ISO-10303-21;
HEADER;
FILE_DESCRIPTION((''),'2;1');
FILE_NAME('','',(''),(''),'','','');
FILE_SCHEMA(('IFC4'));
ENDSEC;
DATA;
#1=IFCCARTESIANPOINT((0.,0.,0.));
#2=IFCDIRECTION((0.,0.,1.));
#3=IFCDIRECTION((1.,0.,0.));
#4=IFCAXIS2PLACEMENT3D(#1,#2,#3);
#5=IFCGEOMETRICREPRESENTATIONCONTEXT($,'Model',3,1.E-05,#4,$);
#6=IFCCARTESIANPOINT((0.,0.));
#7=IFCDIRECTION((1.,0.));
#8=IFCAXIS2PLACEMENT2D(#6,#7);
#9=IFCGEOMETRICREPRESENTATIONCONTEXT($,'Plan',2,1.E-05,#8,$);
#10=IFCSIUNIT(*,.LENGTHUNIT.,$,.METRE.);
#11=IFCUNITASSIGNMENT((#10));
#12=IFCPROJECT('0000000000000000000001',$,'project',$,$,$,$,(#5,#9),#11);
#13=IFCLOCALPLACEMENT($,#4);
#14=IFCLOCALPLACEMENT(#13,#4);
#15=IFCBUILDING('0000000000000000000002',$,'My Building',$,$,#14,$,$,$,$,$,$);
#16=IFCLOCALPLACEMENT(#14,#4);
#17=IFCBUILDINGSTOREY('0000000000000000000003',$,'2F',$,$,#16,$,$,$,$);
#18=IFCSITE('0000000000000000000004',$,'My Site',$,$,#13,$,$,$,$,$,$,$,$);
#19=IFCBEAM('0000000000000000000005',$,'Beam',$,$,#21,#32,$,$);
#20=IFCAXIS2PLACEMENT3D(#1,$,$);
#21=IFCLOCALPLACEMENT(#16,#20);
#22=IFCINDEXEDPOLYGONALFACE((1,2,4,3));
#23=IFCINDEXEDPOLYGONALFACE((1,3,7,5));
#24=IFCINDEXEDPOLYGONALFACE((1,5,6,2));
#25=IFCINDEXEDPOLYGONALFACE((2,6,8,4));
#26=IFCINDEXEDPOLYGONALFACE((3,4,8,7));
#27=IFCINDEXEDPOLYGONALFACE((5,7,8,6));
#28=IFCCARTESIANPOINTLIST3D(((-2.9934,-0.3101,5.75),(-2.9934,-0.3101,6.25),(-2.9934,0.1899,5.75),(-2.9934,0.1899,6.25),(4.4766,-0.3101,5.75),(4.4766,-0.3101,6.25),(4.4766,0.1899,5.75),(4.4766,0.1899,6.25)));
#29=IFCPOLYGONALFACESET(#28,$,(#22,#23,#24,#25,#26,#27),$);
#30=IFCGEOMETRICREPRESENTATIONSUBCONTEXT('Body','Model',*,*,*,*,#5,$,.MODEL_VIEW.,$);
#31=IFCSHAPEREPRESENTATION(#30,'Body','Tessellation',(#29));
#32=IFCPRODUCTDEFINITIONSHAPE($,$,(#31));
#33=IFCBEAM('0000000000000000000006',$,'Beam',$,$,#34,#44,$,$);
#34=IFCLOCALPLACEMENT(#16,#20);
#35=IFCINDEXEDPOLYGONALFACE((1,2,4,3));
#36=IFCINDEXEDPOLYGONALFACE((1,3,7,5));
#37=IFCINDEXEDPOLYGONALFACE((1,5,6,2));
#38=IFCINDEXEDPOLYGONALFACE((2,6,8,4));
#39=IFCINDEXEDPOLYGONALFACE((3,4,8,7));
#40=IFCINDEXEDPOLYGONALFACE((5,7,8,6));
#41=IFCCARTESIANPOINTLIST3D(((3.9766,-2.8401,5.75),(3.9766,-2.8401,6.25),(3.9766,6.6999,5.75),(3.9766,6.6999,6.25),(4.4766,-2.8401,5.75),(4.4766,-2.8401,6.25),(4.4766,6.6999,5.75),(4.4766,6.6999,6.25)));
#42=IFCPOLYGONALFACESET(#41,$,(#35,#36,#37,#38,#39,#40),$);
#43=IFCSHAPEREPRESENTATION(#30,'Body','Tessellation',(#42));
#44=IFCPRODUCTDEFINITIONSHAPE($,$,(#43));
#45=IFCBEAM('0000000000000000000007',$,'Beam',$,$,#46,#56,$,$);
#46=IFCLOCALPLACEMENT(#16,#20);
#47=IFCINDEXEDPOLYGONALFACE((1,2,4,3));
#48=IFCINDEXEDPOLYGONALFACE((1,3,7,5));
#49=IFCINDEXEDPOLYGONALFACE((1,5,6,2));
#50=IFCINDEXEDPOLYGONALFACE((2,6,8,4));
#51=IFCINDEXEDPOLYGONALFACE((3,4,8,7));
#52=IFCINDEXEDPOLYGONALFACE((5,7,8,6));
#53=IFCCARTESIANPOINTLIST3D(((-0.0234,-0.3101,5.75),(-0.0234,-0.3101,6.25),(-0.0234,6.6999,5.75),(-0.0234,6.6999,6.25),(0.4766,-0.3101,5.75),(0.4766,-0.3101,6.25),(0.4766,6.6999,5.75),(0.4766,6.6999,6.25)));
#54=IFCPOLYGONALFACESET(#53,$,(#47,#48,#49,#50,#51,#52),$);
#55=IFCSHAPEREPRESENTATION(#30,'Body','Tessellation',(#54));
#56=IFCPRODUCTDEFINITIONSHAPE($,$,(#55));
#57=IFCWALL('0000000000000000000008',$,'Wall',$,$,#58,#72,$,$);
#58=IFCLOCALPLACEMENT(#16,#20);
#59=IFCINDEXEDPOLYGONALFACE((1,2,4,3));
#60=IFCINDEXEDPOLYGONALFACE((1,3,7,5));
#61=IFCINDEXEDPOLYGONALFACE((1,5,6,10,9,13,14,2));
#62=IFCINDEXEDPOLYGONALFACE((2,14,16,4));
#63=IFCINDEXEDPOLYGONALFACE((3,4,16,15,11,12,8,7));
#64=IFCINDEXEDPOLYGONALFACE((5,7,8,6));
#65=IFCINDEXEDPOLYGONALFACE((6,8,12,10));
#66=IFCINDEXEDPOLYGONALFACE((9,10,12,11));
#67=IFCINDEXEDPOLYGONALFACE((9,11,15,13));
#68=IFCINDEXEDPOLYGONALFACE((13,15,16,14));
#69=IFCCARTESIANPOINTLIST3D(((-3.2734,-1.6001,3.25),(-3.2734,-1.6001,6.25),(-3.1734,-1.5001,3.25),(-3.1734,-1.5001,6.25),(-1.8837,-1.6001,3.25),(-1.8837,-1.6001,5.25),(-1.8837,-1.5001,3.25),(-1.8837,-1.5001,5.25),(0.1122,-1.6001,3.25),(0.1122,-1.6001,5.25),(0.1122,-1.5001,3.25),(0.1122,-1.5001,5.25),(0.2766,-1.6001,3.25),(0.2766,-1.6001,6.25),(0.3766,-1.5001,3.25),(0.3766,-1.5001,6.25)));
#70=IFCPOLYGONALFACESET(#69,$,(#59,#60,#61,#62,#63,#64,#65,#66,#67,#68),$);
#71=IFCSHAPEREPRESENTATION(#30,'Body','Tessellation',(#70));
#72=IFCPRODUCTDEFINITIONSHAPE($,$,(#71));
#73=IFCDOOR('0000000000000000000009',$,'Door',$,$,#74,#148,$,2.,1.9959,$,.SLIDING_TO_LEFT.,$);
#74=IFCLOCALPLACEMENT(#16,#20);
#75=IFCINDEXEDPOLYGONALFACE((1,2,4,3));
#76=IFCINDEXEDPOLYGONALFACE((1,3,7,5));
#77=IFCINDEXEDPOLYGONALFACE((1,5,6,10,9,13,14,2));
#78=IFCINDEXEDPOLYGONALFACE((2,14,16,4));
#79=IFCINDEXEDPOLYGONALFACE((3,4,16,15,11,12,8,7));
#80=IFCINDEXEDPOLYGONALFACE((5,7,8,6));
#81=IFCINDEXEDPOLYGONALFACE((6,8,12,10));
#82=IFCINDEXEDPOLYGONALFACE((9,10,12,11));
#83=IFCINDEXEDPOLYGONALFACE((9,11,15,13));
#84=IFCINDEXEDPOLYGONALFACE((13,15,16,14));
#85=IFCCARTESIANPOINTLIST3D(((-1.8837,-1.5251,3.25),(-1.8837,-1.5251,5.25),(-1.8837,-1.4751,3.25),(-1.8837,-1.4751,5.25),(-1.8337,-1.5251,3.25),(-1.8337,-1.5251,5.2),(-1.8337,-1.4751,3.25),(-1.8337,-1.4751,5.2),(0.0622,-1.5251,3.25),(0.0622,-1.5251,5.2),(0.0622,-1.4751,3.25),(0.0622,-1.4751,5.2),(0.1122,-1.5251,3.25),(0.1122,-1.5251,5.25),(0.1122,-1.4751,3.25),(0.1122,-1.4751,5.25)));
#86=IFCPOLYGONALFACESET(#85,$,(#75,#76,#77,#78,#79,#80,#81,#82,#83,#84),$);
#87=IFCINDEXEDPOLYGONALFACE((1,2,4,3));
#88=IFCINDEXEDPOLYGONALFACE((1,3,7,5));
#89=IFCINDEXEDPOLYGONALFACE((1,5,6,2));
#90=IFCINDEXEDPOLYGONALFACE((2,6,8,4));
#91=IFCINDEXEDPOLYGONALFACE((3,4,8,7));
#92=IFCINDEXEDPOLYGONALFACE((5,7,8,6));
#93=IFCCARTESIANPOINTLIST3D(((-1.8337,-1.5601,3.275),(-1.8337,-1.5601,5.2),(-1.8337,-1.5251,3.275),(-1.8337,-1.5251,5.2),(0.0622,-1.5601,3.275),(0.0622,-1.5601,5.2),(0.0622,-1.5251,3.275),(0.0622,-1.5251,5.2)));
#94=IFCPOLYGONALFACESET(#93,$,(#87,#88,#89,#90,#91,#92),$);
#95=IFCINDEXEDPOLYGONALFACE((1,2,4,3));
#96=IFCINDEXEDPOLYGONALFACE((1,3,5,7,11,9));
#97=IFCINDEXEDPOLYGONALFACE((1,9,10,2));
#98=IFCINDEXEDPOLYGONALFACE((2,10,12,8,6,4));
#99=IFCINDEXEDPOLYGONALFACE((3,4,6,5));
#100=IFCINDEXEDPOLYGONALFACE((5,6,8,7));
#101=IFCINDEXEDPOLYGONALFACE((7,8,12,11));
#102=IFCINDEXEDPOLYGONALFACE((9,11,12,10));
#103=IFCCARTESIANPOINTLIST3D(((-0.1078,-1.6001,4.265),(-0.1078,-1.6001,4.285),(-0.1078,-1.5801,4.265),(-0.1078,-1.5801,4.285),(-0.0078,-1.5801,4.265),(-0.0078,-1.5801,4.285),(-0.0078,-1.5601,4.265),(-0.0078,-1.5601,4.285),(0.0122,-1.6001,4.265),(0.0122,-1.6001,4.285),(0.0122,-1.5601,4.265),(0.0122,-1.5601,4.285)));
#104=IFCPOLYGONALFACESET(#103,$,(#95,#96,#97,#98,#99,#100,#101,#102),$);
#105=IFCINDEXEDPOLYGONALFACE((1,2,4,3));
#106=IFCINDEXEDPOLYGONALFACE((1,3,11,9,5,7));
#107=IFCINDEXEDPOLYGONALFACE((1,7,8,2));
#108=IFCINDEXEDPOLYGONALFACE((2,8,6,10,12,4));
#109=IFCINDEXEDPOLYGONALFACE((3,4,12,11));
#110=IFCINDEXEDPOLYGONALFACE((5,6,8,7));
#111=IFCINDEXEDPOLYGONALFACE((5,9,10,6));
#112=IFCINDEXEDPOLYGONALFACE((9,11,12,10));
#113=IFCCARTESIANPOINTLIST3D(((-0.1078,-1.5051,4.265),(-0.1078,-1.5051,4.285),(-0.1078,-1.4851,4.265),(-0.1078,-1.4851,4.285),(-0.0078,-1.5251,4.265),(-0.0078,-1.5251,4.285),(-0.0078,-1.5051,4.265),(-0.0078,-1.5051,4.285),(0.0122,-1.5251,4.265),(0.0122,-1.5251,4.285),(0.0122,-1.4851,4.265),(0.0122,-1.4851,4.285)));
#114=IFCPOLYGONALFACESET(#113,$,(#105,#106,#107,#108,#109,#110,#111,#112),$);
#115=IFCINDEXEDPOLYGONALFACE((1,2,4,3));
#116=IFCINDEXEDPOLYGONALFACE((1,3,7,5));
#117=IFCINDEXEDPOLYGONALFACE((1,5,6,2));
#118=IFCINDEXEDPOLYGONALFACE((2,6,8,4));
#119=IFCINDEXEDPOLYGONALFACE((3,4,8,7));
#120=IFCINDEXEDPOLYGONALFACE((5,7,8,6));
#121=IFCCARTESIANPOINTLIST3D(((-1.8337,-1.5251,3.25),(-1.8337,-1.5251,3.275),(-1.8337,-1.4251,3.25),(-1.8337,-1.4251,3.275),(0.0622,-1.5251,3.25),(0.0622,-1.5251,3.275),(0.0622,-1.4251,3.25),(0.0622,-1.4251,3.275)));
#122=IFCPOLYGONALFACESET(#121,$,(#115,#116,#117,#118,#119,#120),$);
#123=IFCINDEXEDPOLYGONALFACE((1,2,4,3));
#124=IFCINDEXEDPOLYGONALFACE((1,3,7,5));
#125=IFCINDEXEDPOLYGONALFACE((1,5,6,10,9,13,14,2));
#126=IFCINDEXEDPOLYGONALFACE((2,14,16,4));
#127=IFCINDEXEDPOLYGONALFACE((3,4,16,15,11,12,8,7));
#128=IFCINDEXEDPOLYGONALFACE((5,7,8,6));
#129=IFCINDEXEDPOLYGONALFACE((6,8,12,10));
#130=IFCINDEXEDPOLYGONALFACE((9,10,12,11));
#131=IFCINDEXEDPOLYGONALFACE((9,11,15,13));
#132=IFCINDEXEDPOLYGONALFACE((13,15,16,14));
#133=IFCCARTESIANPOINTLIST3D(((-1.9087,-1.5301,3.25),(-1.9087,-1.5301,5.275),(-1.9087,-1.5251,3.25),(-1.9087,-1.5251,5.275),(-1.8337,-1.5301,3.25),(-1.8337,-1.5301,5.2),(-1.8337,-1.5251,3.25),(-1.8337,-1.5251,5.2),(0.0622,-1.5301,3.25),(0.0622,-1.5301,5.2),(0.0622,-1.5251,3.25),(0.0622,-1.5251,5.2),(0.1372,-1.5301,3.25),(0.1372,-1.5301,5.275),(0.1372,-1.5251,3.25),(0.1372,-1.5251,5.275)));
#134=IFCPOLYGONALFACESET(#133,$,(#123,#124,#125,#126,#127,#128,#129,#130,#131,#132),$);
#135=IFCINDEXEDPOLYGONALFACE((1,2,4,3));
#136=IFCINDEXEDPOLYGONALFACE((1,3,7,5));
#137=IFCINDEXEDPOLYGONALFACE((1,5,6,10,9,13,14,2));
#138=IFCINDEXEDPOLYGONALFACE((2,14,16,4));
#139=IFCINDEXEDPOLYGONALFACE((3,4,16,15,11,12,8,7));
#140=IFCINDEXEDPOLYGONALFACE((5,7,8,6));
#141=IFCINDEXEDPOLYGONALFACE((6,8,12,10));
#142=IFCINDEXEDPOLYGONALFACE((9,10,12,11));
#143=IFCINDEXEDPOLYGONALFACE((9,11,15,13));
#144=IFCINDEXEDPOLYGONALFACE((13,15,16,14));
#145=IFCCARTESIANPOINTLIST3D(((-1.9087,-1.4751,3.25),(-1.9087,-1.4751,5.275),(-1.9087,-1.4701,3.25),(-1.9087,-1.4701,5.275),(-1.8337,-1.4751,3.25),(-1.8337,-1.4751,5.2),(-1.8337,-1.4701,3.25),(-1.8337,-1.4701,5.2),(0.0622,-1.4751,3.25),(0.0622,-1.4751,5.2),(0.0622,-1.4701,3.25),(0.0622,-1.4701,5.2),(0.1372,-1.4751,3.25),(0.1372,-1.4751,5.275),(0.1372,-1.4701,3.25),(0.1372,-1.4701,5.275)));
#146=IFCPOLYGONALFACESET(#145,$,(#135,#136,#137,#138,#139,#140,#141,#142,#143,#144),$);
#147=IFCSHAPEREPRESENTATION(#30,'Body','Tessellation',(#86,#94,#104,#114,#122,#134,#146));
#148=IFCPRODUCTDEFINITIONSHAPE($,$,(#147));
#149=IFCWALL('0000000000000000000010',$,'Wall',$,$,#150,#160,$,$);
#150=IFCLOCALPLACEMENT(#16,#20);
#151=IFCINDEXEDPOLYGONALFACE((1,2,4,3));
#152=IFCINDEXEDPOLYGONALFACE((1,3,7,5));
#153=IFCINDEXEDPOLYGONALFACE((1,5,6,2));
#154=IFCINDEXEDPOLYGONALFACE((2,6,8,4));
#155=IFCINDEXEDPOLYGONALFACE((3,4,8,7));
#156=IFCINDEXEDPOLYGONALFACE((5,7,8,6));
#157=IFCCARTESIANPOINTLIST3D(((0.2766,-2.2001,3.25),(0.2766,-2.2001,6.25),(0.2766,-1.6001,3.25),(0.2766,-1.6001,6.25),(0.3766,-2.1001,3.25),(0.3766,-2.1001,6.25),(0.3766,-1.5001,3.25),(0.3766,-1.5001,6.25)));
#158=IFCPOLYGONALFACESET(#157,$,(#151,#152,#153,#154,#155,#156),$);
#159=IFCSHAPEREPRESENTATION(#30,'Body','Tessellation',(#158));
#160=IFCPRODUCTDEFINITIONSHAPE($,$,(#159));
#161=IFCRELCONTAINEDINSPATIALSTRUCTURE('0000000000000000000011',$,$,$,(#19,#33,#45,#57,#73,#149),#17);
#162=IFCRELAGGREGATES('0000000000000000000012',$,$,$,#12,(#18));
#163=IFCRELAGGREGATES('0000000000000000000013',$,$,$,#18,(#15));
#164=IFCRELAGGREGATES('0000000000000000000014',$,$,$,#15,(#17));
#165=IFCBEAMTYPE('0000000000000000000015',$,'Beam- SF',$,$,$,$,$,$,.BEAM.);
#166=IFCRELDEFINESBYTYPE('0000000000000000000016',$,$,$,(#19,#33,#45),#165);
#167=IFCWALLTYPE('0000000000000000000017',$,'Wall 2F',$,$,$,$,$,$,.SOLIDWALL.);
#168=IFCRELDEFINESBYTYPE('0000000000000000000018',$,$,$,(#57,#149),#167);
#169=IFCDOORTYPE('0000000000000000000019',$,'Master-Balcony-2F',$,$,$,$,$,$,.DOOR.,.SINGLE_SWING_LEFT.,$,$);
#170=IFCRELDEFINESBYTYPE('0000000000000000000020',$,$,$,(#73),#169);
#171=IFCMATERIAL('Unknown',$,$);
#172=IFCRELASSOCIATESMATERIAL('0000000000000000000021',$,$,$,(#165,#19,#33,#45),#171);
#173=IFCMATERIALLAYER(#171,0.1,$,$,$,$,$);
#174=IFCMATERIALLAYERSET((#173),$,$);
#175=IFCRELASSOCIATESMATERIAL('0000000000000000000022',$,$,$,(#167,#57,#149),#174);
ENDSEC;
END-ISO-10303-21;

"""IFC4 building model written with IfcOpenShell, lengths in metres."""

from ifc_helpers import new_model, entity, si_unit, frame, origin_with_axes, origin_2d_with_axis, place, context, subcontext, project, spatial, line, indexed_curve, rectangle, outline, extrude, shape, source, transform, mapped, material, layer, layer_set, layer_usage, material_profile, profile_set, profile_usage, type_object, type_shapes, element, fill, save


model = new_model("IFC4")

# Units and contexts
model_context = context("Model", 3, precision=1e-05, world=origin_with_axes())
plan_context = context("Plan", 2, precision=1e-05, world=origin_2d_with_axis())
body_context_1 = subcontext(model_context, "Body", "Model", "MODEL_VIEW")
body_context_2 = subcontext(plan_context, "Body", "Plan", "PLAN_VIEW")
ifc_project = project(units=[si_unit("LENGTHUNIT", "METRE")], contexts=[model_context, plan_context])

# Site, building, storey
site_placement = place(None, origin_with_axes())
site = spatial("IfcSite", under=ifc_project, at=site_placement, Name="My Site")
building_placement = place(site_placement, origin_with_axes())
building = spatial("IfcBuilding", under=site, at=building_placement, Name="My Building")
storey_placement = place(building_placement, origin_with_axes())
storey = spatial("IfcBuildingStorey", under=building, at=storey_placement, Name="2F")

# Beams
ifc_material = material(Name="Unknown")
ifc_material_profile = material_profile(ifc_material, rectangle(XDim=0.5, YDim=0.5))
ifc_profile_set = profile_set([ifc_material_profile])
ifc_profile_usage_1 = profile_usage(ifc_profile_set, cardinal=5)
beam_type = type_object("IfcBeamType", Name="Beam- SF", PredefinedType="BEAM", material=ifc_profile_set)
beam_1_placement = place(storey_placement, frame((4.4766, -0.0601, 6.0), z_axis=(-1.0, -0.000001, 0.000001), x_axis=(0.000001, -1.0, 0.0)))
element("IfcBeam", 1, at=beam_1_placement, inside=storey, type_object=beam_type, material=ifc_profile_usage_1, Name="Beam", context=body_context_1, shape_type="SweptSolid", body=[
    extrude(rectangle(XDim=0.5, YDim=0.5), origin_with_axes(), (0.0, 0.0, 1.0), 7.47),
])
ifc_profile_usage_2 = profile_usage(ifc_profile_set, cardinal=5)
beam_2_placement = place(storey_placement, frame((4.2266, -2.8401, 6.0), z_axis=(0.0, 1.0, 0.0), x_axis=(-1.0, 0.0, 0.0)))
element("IfcBeam", 2, at=beam_2_placement, inside=storey, type_object=beam_type, material=ifc_profile_usage_2, Name="Beam", context=body_context_1, shape_type="SweptSolid", body=[
    extrude(rectangle(XDim=0.5, YDim=0.5), origin_with_axes(), (0.0, 0.0, 1.0), 9.54),
])
ifc_profile_usage_3 = profile_usage(ifc_profile_set, cardinal=5)
beam_3_placement = place(storey_placement, frame((0.2266, -0.3101, 6.0), z_axis=(0.0, 1.0, 0.0), x_axis=(-1.0, 0.0, 0.0)))
element("IfcBeam", 3, at=beam_3_placement, inside=storey, type_object=beam_type, material=ifc_profile_usage_3, Name="Beam", context=body_context_1, shape_type="SweptSolid", body=[
    extrude(rectangle(XDim=0.5, YDim=0.5), origin_with_axes(), (0.0, 0.0, 1.0), 7.01),
])

# Wall, opening, door
ifc_layer = layer(ifc_material, 0.1)
ifc_layer_set = layer_set([ifc_layer])
ifc_layer_usage_1 = layer_usage(ifc_layer_set, "AXIS2", "POSITIVE", 0.0)
wall_type = type_object("IfcWallType", Name="Wall 2F", PredefinedType="SOLIDWALL", material=ifc_layer_set)
wall_1_placement = place(storey_placement, frame((-3.2734, -1.6001, 3.25), z_axis=(0.0, 0.0, 1.0), x_axis=(1.0, 0.0, 0.0)))
wall_1 = element("IfcWall", 4, at=wall_1_placement, inside=storey, type_object=wall_type, material=ifc_layer_usage_1, Name="Wall", context=body_context_1, shape_type="SweptSolid", body=[
    extrude(outline(indexed_curve([(0.0, 0.0), (0.1, 0.1), (3.65, 0.1), (3.55, 0.0)], segments=[line(1, 2, 3, 4, 1)])), origin_with_axes(), (0.0, 0.0, 1.0), 3.0),
])
shared_shape_1 = source(origin_with_axes(), body_context_1, "Body", "SweptSolid", [
    extrude(outline(indexed_curve([(0.0, 0.0), (1.9959, 0.0), (1.9959, 2.0), (0.0, 2.0)], segments=[line(1, 2, 3, 4, 1)])), frame((0.0, -0.6, 0.0), z_axis=(0.0, -1.0, 0.0), x_axis=(1.0, 0.0, 0.0)), (0.0, 0.0, -1.0), 1.2),
])
opening_1_placement = place(wall_1_placement, frame((1.3897, 0.075, 0.0), z_axis=(0.0, 0.0, 1.0), x_axis=(1.0, 0.0, 0.0)))
opening_1 = element("IfcOpeningElement", 5, at=opening_1_placement, cuts=wall_1, PredefinedType="OPENING", context=body_context_1, shape_type="MappedRepresentation", body=[
    mapped(shared_shape_1, transform((0.0, 0.0, 0.0), x_axis=(1.0, 0.0, 0.0), y_axis=(0.0, 1.0, 0.0), z_axis=(0.0, 0.0, 1.0), scale=1.0)),
])
door_type_1 = type_object("IfcDoorType", Name="Master-Balcony-2F", OperationType="SINGLE_SWING_LEFT", PredefinedType="DOOR")
shared_shape_2 = source(origin_with_axes(), body_context_1, "Body", "SweptSolid", [
    extrude(outline(indexed_curve([(0.0, 0.0), (0.0, 2.0), (1.9959, 2.0), (1.9959, 0.0), (1.9459, 0.0), (1.9459, 1.95), (0.05, 1.95), (0.05, 0.0)], segments=[line(1, 2, 3, 4, 5, 6, 7, 8, 1)])), frame((0.0, 0.0, 0.0), z_axis=(0.0, -1.0, 0.0), x_axis=(1.0, 0.0, 0.0)), (0.0, 0.0, -1.0), 0.05),
    extrude(outline(indexed_curve([(0.0, 0.0), (1.8959, 0.0), (1.8959, 0.035), (0.0, 0.035)], segments=[line(1, 2, 3, 4, 1)])), frame((0.05, -0.035, 0.025), z_axis=(0.0, 0.0, 1.0), x_axis=(1.0, 0.0, 0.0)), (0.0, 0.0, 1.0), 1.925),
    extrude(outline(indexed_curve([(0.0, 0.0), (0.0, -0.04), (-0.12, -0.04), (-0.12, -0.02), (-0.02, -0.02), (-0.02, 0.0)], segments=[line(1, 2, 3, 4, 5, 6, 1)])), frame((1.8959, -0.035, 1.015), z_axis=(0.0, 0.0, 1.0), x_axis=(1.0, 0.0, 0.0)), (0.0, 0.0, 1.0), 0.02),
    extrude(outline(indexed_curve([(0.0, 0.0), (0.0, 0.04), (-0.12, 0.04), (-0.12, 0.02), (-0.02, 0.02), (-0.02, 0.0)], segments=[line(1, 2, 3, 4, 5, 6, 1)])), frame((1.8959, 0.0, 1.015), z_axis=(0.0, 0.0, 1.0), x_axis=(1.0, 0.0, 0.0)), (0.0, 0.0, 1.0), 0.02),
    extrude(outline(indexed_curve([(0.0, 0.0), (1.8959, 0.0), (1.8959, 0.1), (0.0, 0.1)], segments=[line(1, 2, 3, 4, 1)])), frame((0.05, 0.0, 0.0), z_axis=(0.0, 0.0, 1.0), x_axis=(1.0, 0.0, 0.0)), (0.0, 0.0, 1.0), 0.025),
    extrude(outline(indexed_curve([(0.0, 0.0), (0.0, 2.025), (2.0459, 2.025), (2.0459, 0.0), (1.9709, 0.0), (1.9709, 1.95), (0.075, 1.95), (0.075, 0.0)], segments=[line(1, 2, 3, 4, 5, 6, 7, 8, 1)])), frame((-0.025, -0.005, 0.0), z_axis=(0.0, -1.0, 0.0), x_axis=(1.0, 0.0, 0.0)), (0.0, 0.0, -1.0), 0.005),
    extrude(outline(indexed_curve([(0.0, 0.0), (0.0, 2.025), (2.0459, 2.025), (2.0459, 0.0), (1.9709, 0.0), (1.9709, 1.95), (0.075, 1.95), (0.075, 0.0)], segments=[line(1, 2, 3, 4, 5, 6, 7, 8, 1)])), frame((-0.025, 0.05, 0.0), z_axis=(0.0, -1.0, 0.0), x_axis=(1.0, 0.0, 0.0)), (0.0, 0.0, -1.0), 0.005),
])
shared_shape_3 = source(origin_with_axes(), body_context_2, "Body", "Curve2D", [
    entity("IfcIndexedPolyCurve", entity("IfcCartesianPointList2D", [[0.0, 0.0], [0.05, 0.0], [0.05, 0.05], [0.0, 0.05]]), [entity("IfcLineIndex", [1, 2, 3, 4, 1])]),
    entity("IfcIndexedPolyCurve", entity("IfcCartesianPointList2D", [[1.9959, 0.0], [1.9459, 0.0], [1.9459, 0.05], [1.9959, 0.05]]), [entity("IfcLineIndex", [1, 2, 3, 4, 1])]),
    entity("IfcIndexedPolyCurve", entity("IfcCartesianPointList2D", [[-0.8979, -0.035], [0.9979, -0.035], [0.9979, 0.0], [-0.8979, 0.0]]), [entity("IfcLineIndex", [1, 2, 3, 4, 1])]),
])
type_shapes(door_type_1, [shared_shape_2, shared_shape_3])
door_1_placement = place(opening_1_placement, frame((0.0, 0.0, 0.0), z_axis=(0.0, 0.0, 1.0), x_axis=(1.0, 0.0, 0.0)))
door_1 = element("IfcDoor", 6, at=door_1_placement, inside=storey, type_object=door_type_1, Name="Door", OperationType="SLIDING_TO_LEFT", OverallHeight=2.0, OverallWidth=1.9959, shapes=[
    shape(body_context_1, "Body", "MappedRepresentation", [mapped(shared_shape_2, transform((0.0, 0.0, 0.0), x_axis=(1.0, 0.0, 0.0), y_axis=(0.0, 1.0, 0.0), z_axis=(0.0, 0.0, 1.0), scale=1.0))]),
    shape(body_context_2, "Body", "MappedRepresentation", [mapped(shared_shape_3, transform((0.0, 0.0, 0.0), x_axis=(1.0, 0.0, 0.0), y_axis=(0.0, 1.0, 0.0), z_axis=(0.0, 0.0, 1.0), scale=1.0))]),
])
fill(opening_1, door_1)

# Wall
ifc_layer_usage_2 = layer_usage(ifc_layer_set, "AXIS2", "POSITIVE", 0.0)
wall_2_placement = place(storey_placement, frame((0.2766, -1.6001, 3.25), z_axis=(0.0, 0.0, 1.0), x_axis=(0.0, -1.0, 0.0)))
element("IfcWall", 7, at=wall_2_placement, inside=storey, type_object=wall_type, material=ifc_layer_usage_2, Name="Wall", context=body_context_1, shape_type="SweptSolid", body=[
    extrude(outline(indexed_curve([(0.0, 0.0), (-0.1, 0.1), (0.5, 0.1), (0.6, 0.0)], segments=[line(1, 2, 3, 4, 1)])), origin_with_axes(), (0.0, 0.0, 1.0), 3.0),
])

save(model, "model.ifc")
